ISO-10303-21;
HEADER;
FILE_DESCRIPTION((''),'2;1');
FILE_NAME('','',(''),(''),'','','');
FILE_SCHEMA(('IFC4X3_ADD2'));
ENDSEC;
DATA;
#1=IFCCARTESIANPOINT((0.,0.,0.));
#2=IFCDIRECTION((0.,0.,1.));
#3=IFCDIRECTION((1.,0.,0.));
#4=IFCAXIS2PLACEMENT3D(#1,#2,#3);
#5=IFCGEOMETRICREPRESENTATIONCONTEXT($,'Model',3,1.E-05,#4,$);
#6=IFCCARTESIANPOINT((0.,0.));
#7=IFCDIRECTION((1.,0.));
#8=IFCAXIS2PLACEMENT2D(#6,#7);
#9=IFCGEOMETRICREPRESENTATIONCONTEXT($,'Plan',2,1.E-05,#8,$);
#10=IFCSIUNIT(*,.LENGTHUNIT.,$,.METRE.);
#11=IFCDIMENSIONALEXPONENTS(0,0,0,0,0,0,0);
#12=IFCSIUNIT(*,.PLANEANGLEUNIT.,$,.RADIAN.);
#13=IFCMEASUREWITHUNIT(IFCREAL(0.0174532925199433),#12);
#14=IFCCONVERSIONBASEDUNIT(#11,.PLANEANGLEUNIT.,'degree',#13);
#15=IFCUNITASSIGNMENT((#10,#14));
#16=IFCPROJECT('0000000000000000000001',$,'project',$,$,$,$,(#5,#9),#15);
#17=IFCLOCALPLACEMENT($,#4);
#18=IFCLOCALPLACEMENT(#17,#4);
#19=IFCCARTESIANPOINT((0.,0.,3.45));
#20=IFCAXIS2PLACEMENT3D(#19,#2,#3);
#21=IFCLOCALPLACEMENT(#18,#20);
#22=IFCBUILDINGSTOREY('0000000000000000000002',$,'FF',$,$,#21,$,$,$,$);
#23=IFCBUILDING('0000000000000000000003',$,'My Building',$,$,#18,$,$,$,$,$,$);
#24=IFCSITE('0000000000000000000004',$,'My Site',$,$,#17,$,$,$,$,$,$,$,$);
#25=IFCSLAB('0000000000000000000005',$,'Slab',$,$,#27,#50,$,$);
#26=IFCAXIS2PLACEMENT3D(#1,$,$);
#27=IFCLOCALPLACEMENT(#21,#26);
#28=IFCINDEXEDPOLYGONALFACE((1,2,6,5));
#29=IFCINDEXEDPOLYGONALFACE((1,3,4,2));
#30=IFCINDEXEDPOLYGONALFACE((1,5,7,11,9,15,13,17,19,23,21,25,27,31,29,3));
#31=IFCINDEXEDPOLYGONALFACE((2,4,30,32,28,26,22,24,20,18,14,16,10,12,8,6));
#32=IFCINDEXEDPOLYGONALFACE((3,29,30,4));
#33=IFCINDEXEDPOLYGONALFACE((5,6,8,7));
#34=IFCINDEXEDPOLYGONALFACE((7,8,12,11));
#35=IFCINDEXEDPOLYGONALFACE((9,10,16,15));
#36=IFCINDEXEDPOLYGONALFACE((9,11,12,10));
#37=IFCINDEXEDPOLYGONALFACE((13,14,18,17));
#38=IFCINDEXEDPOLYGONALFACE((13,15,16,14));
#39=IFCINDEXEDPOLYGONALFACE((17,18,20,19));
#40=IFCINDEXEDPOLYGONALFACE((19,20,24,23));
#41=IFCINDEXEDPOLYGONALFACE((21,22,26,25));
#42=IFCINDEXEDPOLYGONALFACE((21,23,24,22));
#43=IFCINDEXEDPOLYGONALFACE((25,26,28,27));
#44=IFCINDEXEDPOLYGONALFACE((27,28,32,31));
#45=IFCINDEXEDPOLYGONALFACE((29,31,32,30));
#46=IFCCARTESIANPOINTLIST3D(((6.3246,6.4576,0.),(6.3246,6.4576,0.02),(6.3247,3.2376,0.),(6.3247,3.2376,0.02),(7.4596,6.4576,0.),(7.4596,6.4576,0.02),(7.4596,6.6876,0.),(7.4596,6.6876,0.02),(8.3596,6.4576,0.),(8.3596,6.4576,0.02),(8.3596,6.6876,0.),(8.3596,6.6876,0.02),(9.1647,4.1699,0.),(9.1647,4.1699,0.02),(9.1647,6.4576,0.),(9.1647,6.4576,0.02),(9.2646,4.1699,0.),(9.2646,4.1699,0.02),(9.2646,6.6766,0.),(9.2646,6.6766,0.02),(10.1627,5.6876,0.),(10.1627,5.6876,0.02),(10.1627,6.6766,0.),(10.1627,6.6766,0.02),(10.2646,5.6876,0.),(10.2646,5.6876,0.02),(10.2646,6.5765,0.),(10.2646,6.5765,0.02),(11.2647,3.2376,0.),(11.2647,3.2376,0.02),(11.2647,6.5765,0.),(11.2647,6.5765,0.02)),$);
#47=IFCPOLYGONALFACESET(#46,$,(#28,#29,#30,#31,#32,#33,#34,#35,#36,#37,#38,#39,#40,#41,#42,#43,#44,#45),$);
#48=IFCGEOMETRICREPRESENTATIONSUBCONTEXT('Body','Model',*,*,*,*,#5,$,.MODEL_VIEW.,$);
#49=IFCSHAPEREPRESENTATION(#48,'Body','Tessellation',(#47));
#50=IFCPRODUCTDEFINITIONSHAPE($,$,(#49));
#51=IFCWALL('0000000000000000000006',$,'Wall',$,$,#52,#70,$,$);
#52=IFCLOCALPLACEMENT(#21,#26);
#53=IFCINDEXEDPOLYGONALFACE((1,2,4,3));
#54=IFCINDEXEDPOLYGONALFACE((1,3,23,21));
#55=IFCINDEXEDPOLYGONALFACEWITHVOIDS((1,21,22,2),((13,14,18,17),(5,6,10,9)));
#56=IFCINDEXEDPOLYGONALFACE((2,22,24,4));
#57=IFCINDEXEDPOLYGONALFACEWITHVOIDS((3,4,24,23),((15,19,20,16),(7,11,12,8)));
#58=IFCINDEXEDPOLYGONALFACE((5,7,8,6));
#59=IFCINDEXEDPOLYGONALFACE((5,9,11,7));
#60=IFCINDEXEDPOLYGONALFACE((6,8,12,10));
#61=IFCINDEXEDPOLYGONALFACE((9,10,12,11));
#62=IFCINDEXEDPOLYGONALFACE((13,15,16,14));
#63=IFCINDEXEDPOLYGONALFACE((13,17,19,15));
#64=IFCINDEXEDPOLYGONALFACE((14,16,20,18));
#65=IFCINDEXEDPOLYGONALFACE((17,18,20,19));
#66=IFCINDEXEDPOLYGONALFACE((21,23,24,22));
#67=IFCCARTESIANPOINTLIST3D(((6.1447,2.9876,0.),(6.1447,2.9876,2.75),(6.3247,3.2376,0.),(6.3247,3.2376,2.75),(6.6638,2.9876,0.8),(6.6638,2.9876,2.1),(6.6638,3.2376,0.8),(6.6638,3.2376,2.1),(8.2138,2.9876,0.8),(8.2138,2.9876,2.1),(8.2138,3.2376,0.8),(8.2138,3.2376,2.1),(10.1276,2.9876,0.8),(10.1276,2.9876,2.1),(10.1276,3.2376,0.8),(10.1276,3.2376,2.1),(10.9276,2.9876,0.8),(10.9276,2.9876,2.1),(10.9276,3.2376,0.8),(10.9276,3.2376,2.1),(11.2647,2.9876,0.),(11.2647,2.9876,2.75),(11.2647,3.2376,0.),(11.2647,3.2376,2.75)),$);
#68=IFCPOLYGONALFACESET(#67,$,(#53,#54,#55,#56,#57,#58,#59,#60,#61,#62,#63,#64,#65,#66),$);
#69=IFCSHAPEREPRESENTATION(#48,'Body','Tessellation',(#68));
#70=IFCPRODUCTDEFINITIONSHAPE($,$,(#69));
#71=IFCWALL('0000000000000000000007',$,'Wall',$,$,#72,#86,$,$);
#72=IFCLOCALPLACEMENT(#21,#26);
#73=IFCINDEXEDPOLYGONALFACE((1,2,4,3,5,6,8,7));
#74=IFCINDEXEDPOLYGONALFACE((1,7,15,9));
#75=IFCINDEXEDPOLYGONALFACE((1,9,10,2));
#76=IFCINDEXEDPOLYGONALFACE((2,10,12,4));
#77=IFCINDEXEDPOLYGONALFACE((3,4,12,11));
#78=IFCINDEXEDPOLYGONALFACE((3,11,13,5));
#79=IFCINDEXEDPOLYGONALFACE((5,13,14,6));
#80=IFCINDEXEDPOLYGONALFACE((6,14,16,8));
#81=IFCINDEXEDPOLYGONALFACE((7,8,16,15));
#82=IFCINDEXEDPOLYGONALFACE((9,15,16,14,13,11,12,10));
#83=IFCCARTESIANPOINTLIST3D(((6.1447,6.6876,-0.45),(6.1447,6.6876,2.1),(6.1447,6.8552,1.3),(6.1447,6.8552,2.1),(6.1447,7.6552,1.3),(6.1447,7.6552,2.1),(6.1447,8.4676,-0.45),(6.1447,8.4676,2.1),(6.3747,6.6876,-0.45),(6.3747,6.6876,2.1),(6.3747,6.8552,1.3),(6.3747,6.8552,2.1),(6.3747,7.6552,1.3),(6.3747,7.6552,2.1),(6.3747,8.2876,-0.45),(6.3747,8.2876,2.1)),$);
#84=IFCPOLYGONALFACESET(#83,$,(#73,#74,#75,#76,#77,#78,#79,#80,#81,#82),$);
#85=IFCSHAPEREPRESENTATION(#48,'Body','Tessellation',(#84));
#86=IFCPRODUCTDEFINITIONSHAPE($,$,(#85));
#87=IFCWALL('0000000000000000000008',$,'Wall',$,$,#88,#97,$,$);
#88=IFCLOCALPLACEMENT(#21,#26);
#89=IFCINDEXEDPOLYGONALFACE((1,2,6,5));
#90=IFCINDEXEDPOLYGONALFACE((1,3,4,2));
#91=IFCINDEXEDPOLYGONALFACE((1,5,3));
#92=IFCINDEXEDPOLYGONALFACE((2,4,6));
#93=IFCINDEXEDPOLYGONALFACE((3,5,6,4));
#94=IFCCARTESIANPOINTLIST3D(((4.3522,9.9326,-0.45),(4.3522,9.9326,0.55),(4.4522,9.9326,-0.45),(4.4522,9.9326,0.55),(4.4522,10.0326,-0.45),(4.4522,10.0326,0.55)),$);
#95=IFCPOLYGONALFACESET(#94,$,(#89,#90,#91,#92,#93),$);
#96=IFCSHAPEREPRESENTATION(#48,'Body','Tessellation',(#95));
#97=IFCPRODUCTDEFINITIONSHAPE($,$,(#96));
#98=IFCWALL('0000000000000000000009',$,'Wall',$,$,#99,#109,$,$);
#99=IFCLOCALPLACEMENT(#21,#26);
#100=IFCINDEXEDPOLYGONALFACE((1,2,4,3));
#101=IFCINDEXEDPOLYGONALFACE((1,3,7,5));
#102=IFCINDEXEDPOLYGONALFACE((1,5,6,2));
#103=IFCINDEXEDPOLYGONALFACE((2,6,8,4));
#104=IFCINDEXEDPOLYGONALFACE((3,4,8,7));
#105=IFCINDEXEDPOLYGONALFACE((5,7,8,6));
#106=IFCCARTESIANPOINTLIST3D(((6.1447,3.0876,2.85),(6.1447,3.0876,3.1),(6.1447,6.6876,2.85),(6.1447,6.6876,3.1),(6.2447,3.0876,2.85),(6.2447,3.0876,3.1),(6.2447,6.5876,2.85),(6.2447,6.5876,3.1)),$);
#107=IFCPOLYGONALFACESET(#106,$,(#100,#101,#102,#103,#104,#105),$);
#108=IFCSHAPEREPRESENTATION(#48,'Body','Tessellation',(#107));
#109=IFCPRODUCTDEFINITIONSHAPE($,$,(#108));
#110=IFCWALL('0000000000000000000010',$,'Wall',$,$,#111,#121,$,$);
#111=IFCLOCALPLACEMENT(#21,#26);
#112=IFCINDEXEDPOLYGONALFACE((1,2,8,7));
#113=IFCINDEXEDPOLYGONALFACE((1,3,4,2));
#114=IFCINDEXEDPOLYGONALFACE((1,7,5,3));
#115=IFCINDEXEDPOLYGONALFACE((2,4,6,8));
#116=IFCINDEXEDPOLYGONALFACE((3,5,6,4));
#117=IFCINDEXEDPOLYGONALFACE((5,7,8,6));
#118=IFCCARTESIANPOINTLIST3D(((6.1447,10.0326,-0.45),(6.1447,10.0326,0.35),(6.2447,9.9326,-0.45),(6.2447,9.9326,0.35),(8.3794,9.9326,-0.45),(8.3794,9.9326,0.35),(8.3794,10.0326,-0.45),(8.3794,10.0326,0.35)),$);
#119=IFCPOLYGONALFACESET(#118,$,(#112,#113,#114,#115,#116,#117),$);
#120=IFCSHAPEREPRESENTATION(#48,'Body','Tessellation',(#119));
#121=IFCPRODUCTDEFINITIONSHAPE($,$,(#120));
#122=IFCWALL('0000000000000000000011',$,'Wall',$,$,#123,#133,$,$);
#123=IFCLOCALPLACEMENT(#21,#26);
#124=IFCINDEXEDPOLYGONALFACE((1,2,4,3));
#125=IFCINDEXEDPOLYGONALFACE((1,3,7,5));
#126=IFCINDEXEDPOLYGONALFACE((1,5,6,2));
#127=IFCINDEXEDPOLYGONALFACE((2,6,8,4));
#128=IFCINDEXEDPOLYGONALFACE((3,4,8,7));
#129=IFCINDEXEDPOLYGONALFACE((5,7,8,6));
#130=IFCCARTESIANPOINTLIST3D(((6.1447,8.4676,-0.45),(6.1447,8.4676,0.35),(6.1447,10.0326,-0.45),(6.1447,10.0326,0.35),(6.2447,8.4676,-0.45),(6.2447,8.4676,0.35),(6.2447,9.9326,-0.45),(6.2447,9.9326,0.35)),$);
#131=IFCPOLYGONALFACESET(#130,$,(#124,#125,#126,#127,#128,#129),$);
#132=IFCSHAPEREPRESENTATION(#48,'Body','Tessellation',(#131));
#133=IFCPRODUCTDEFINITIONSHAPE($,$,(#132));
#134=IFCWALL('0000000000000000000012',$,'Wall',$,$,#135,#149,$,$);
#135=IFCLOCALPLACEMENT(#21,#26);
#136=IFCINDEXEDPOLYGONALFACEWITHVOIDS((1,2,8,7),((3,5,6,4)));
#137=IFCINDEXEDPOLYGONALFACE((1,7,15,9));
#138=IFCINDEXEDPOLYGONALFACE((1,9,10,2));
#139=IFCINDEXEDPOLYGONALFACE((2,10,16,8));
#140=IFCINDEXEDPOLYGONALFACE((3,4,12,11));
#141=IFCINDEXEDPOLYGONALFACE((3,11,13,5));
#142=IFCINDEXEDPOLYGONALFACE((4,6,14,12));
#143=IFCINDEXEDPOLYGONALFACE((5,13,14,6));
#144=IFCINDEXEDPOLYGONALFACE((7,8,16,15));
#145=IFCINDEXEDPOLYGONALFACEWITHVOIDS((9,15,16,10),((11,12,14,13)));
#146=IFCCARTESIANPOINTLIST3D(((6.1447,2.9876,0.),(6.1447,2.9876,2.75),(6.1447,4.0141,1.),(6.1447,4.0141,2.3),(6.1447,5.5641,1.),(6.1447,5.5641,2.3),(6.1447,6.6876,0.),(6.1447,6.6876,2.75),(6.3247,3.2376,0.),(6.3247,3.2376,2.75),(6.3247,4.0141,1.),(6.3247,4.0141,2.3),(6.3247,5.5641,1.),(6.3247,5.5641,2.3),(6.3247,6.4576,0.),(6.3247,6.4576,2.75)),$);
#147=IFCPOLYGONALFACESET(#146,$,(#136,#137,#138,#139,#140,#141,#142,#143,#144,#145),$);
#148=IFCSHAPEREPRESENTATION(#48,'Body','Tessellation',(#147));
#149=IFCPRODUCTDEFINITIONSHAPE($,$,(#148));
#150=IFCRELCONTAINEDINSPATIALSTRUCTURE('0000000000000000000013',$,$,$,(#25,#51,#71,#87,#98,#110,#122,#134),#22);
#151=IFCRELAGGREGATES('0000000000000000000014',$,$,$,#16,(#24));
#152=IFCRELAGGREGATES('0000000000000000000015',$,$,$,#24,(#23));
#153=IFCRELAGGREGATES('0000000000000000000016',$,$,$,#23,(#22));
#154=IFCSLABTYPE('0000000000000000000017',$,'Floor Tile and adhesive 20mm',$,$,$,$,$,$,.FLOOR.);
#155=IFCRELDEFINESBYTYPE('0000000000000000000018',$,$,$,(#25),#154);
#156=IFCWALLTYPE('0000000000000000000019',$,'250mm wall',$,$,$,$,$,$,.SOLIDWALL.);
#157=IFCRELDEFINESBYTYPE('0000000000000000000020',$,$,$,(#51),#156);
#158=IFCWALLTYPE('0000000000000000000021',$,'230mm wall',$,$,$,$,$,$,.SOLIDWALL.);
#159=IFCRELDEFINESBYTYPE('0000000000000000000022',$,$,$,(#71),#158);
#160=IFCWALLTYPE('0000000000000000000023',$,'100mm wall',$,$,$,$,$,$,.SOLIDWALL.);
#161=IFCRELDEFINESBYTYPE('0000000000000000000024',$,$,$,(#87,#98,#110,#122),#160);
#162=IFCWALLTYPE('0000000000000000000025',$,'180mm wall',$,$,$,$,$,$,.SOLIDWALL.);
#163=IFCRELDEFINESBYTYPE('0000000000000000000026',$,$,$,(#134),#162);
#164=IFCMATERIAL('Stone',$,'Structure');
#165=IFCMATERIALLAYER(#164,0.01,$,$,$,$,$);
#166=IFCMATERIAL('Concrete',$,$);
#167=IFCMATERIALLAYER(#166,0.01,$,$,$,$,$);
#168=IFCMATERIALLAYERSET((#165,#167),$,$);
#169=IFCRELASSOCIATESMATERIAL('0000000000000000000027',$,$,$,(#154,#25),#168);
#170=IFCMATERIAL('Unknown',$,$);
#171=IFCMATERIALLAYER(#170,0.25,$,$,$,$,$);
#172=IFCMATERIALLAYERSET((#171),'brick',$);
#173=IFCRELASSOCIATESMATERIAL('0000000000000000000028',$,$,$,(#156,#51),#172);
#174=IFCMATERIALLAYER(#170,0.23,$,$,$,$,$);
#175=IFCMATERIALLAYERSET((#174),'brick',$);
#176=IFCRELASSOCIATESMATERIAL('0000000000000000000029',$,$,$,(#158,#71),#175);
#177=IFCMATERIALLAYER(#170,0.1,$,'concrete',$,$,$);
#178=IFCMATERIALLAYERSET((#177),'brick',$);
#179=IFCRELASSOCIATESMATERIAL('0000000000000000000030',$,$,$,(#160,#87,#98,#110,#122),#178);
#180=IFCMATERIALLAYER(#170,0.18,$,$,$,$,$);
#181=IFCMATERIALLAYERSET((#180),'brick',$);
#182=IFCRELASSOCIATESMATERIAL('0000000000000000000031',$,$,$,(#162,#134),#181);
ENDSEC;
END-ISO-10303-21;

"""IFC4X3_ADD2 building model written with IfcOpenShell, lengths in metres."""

from ifc_helpers import new_model, entity, si_unit, converted_unit, frame, origin_with_axes, origin_2d_with_axis, place, context, subcontext, project, spatial, line, indexed_curve, outline, extrude, source, transform, mapped, material, layer, layer_set, layer_usage, type_object, element, save


model = new_model("IFC4X3_ADD2")

# Units and contexts
model_context = context("Model", 3, precision=1e-05, world=origin_with_axes())
plan_context = context("Plan", 2, precision=1e-05, world=origin_2d_with_axis())
body_context = subcontext(model_context, "Body", "Model", "MODEL_VIEW")
ifc_project = project(units=[si_unit("LENGTHUNIT", "METRE"), converted_unit("PLANEANGLEUNIT", "degree", entity("IfcReal", 0.0174532925199433), si_unit("PLANEANGLEUNIT", "RADIAN"), dimensions=[0, 0, 0, 0, 0, 0, 0])], contexts=[model_context, plan_context])

# Site, building, storey
site_placement = place(None, origin_with_axes())
site = spatial("IfcSite", under=ifc_project, at=site_placement, Name="My Site")
building_placement = place(site_placement, origin_with_axes())
building = spatial("IfcBuilding", under=site, at=building_placement, Name="My Building")
storey_placement = place(building_placement, frame((0.0, 0.0, 3.45), z_axis=(0.0, 0.0, 1.0), x_axis=(1.0, 0.0, 0.0)))
storey = spatial("IfcBuildingStorey", under=building, at=storey_placement, Name="FF")

# Slab
ifc_material_1 = material(Name="Stone", Category="Structure")
ifc_layer_1 = layer(ifc_material_1, 0.01)
ifc_material_2 = material(Name="Concrete")
ifc_layer_2 = layer(ifc_material_2, 0.01)
ifc_layer_set_1 = layer_set([ifc_layer_1, ifc_layer_2])
ifc_layer_usage_1 = layer_usage(ifc_layer_set_1, "AXIS3", "POSITIVE", -0.02)
slab_type = type_object("IfcSlabType", Name="Floor Tile and adhesive 20mm", PredefinedType="FLOOR", material=ifc_layer_set_1)
slab_1_placement = place(storey_placement, frame((6.3247, 3.2376, 0.02), z_axis=(0.0, 0.0, 1.0), x_axis=(1.0, 0.0, 0.0)))
element("IfcSlab", 1, at=slab_1_placement, inside=storey, type_object=slab_type, material=ifc_layer_usage_1, Name="Slab", context=body_context, shape_type="SweptSolid", body=[
    extrude(outline(indexed_curve([(0.0, 0.0), (4.9401, 0.0), (4.9401, 3.339), (3.94, 3.339), (3.94, 2.4501), (3.838, 2.4501), (3.838, 3.439), (2.94, 3.439), (2.94, 0.9323), (2.84, 0.9323), (2.84, 3.22), (2.0349, 3.22), (2.0349, 3.45), (1.1349, 3.45), (1.1349, 3.22), (0.0, 3.22), (0.0, 0.0)])), frame((0.0, 0.0, -0.02), z_axis=(0.0, 0.0, 1.0), x_axis=(1.0, 0.0, 0.0)), (0.0, 0.0, 1.0), 0.02),
])

# Wall, openings
ifc_material_3 = material(Name="Unknown")
ifc_layer_3 = layer(ifc_material_3, 0.25)
ifc_layer_set_2 = layer_set([ifc_layer_3], Name="brick")
ifc_layer_usage_2 = layer_usage(ifc_layer_set_2, "AXIS2", "POSITIVE", 0.0)
wall_type_1 = type_object("IfcWallType", Name="250mm wall", PredefinedType="SOLIDWALL", material=ifc_layer_set_2)
wall_1_placement = place(storey_placement, frame((6.3247, 2.9876, 0.0), z_axis=(0.0, 0.0, 1.0), x_axis=(1.0, 0.0, 0.0)))
wall_1 = element("IfcWall", 2, at=wall_1_placement, inside=storey, type_object=wall_type_1, material=ifc_layer_usage_2, Name="Wall", context=body_context, shape_type="SweptSolid", body=[
    extrude(outline(indexed_curve([(-0.18, 0.0), (0.0, 0.25), (4.94, 0.25), (4.94, 0.0)], segments=[line(1, 2, 3, 4, 1)])), origin_with_axes(), (0.0, 0.0, 1.0), 2.75),
])
shared_shape_1 = source(origin_with_axes(), body_context, "Body", "SweptSolid", [
    extrude(outline(indexed_curve([(0.0, 0.0), (1.55, 0.0), (1.55, 1.3), (0.0, 1.3)], segments=[line(1, 2, 3, 4, 1)])), frame((-0.775, -0.6, 0.0), z_axis=(0.0, -1.0, 0.0), x_axis=(1.0, 0.0, 0.0)), (0.0, 0.0, -1.0), 1.2),
])
opening_1_placement = place(wall_1_placement, frame((1.1142, 0.0, 0.8), z_axis=(0.0, 0.0, 1.0), x_axis=(1.0, 0.0, 0.0)))
element("IfcOpeningElement", 3, at=opening_1_placement, cuts=wall_1, PredefinedType="OPENING", context=body_context, shape_type="MappedRepresentation", body=[
    mapped(shared_shape_1, transform((0.0, 0.0, 0.0), x_axis=(1.0, 0.0, 0.0), y_axis=(0.0, 1.0, 0.0), z_axis=(0.0, 0.0, 1.0), scale=1.0)),
])
shared_shape_2 = source(origin_with_axes(), body_context, "Body", "SweptSolid", [
    extrude(outline(indexed_curve([(0.0, 0.0), (0.8, 0.0), (0.8, 1.3), (0.0, 1.3)], segments=[line(1, 2, 3, 4, 1)])), frame((-0.4, -0.6, 0.0), z_axis=(0.0, -1.0, 0.0), x_axis=(1.0, 0.0, 0.0)), (0.0, 0.0, -1.0), 1.2),
])
opening_2_placement = place(wall_1_placement, frame((4.203, 0.0, 0.8), z_axis=(0.0, 0.0, 1.0), x_axis=(1.0, 0.0, 0.0)))
element("IfcOpeningElement", 4, at=opening_2_placement, cuts=wall_1, PredefinedType="OPENING", context=body_context, shape_type="MappedRepresentation", body=[
    mapped(shared_shape_2, transform((0.0, 0.0, 0.0), x_axis=(1.0, 0.0, 0.0), y_axis=(0.0, 1.0, 0.0), z_axis=(0.0, 0.0, 1.0), scale=1.0)),
])

# Wall, opening
ifc_layer_4 = layer(ifc_material_3, 0.23)
ifc_layer_set_3 = layer_set([ifc_layer_4], Name="brick")
ifc_layer_usage_3 = layer_usage(ifc_layer_set_3, "AXIS2", "POSITIVE", 0.0)
wall_type_2 = type_object("IfcWallType", Name="230mm wall", PredefinedType="SOLIDWALL", material=ifc_layer_set_3)
wall_2_placement = place(storey_placement, frame((6.3747, 6.6876, -0.45), z_axis=(0.0, 0.0, 1.0), x_axis=(0.0, 1.0, 0.0)))
wall_2 = element("IfcWall", 5, at=wall_2_placement, inside=storey, type_object=wall_type_2, material=ifc_layer_usage_3, Name="Wall", context=body_context, shape_type="SweptSolid", body=[
    extrude(outline(indexed_curve([(0.0, 0.0), (0.0, 0.23), (1.78, 0.23), (1.6, 0.0)], segments=[line(1, 2, 3, 4, 1)])), origin_with_axes(), (0.0, 0.0, 1.0), 2.55),
])
shared_shape_3 = source(origin_with_axes(), body_context, "Body", "SweptSolid", [
    extrude(outline(indexed_curve([(0.0, 0.0), (0.8, 0.0), (0.8, 0.8), (0.0, 0.8)], segments=[line(1, 2, 3, 4, 1)])), frame((-0.4, -0.6, 0.0), z_axis=(0.0, -1.0, 0.0), x_axis=(1.0, 0.0, 0.0)), (0.0, 0.0, -1.0), 1.2),
])
opening_3_placement = place(wall_2_placement, frame((0.5677, 0.0, 1.75), z_axis=(0.0, 0.0, 1.0), x_axis=(1.0, 0.0, 0.0)))
element("IfcOpeningElement", 6, at=opening_3_placement, cuts=wall_2, PredefinedType="OPENING", context=body_context, shape_type="MappedRepresentation", body=[
    mapped(shared_shape_3, transform((0.0, 0.0, 0.0), x_axis=(1.0, 0.0, 0.0), y_axis=(0.0, 1.0, 0.0), z_axis=(0.0, 0.0, 1.0), scale=1.0)),
])

# Walls
ifc_layer_5 = layer(ifc_material_3, 0.1, Name="concrete")
ifc_layer_set_4 = layer_set([ifc_layer_5], Name="brick")
ifc_layer_usage_4 = layer_usage(ifc_layer_set_4, "AXIS2", "POSITIVE", 0.0)
wall_type_3 = type_object("IfcWallType", Name="100mm wall", PredefinedType="SOLIDWALL", material=ifc_layer_set_4)
wall_3_placement = place(storey_placement, frame((4.4522, 10.0326, -0.45), z_axis=(0.0, 0.0, 1.0), x_axis=(-1.0, 0.0, 0.0)))
element("IfcWall", 7, at=wall_3_placement, inside=storey, type_object=wall_type_3, material=ifc_layer_usage_4, Name="Wall", context=body_context, shape_type="SweptSolid", body=[
    extrude(outline(indexed_curve([(0.0, 0.0), (0.1, 0.1), (0.0, 0.1), (0.0, 0.0)], segments=[line(1, 2, 3, 4, 1)])), origin_with_axes(), (0.0, 0.0, 1.0), 1.0),
])
ifc_layer_usage_5 = layer_usage(ifc_layer_set_4, "AXIS2", "POSITIVE", 0.0)
wall_4_placement = place(storey_placement, frame((6.2447, 3.0876, 2.85), z_axis=(0.0, 0.0, 1.0), x_axis=(0.0, 1.0, 0.0)))
element("IfcWall", 8, at=wall_4_placement, inside=storey, type_object=wall_type_3, material=ifc_layer_usage_5, Name="Wall", context=body_context, shape_type="SweptSolid", body=[
    extrude(outline(indexed_curve([(0.0, 0.0), (0.0, 0.1), (3.6, 0.1), (3.5, 0.0)], segments=[line(1, 2, 3, 4, 1)])), origin_with_axes(), (0.0, 0.0, 1.0), 0.25),
])
ifc_layer_usage_6 = layer_usage(ifc_layer_set_4, "AXIS2", "POSITIVE", 0.0)
wall_5_placement = place(storey_placement, frame((6.1447, 9.9326, -0.45), z_axis=(0.0, 0.0, 1.0), x_axis=(1.0, 0.0, 0.0)))
element("IfcWall", 9, at=wall_5_placement, inside=storey, type_object=wall_type_3, material=ifc_layer_usage_6, Name="Wall", context=body_context, shape_type="SweptSolid", body=[
    extrude(outline(indexed_curve([(0.1, 0.0), (0.0, 0.1), (2.2347, 0.1), (2.2347, 0.0)], segments=[line(1, 2, 3, 4, 1)])), origin_with_axes(), (0.0, 0.0, 1.0), 0.8),
])
ifc_layer_usage_7 = layer_usage(ifc_layer_set_4, "AXIS2", "POSITIVE", 0.0)
wall_6_placement = place(storey_placement, frame((6.1447, 9.9326, -0.45), z_axis=(0.0, 0.0, 1.0), x_axis=(-0.000001, -1.0, 0.0)))
element("IfcWall", 10, at=wall_6_placement, inside=storey, type_object=wall_type_3, material=ifc_layer_usage_7, Name="Wall", context=body_context, shape_type="SweptSolid", body=[
    extrude(outline(indexed_curve([(-0.1, 0.0), (0.0, 0.1), (1.465, 0.1), (1.465, 0.0)], segments=[line(1, 2, 3, 4, 1)])), origin_with_axes(), (0.0, 0.0, 1.0), 0.8),
])

# Wall, opening
ifc_layer_6 = layer(ifc_material_3, 0.18)
ifc_layer_set_5 = layer_set([ifc_layer_6], Name="brick")
ifc_layer_usage_8 = layer_usage(ifc_layer_set_5, "AXIS2", "POSITIVE", 0.0)
wall_type_4 = type_object("IfcWallType", Name="180mm wall", PredefinedType="SOLIDWALL", material=ifc_layer_set_5)
wall_7_placement = place(storey_placement, frame((6.3247, 2.9876, 0.0), z_axis=(0.0, 0.0, 1.0), x_axis=(0.0, 1.0, 0.0)))
wall_7 = element("IfcWall", 11, at=wall_7_placement, inside=storey, type_object=wall_type_4, material=ifc_layer_usage_8, Name="Wall", context=body_context, shape_type="SweptSolid", body=[
    extrude(outline(indexed_curve([(0.25, 0.0), (0.0, 0.18), (3.7, 0.18), (3.47, 0.0)], segments=[line(1, 2, 3, 4, 1)])), origin_with_axes(), (0.0, 0.0, 1.0), 2.75),
])
opening_4_placement = place(wall_7_placement, frame((1.8015, 0.0, 1.0), z_axis=(0.0, 0.0, 1.0), x_axis=(1.0, 0.0, 0.0)))
element("IfcOpeningElement", 12, at=opening_4_placement, cuts=wall_7, PredefinedType="OPENING", context=body_context, shape_type="MappedRepresentation", body=[
    mapped(shared_shape_1, transform((0.0, 0.0, 0.0), x_axis=(1.0, 0.0, 0.0), y_axis=(0.0, 1.0, 0.0), z_axis=(0.0, 0.0, 1.0), scale=1.0)),
])

save(model, "model.ifc")
